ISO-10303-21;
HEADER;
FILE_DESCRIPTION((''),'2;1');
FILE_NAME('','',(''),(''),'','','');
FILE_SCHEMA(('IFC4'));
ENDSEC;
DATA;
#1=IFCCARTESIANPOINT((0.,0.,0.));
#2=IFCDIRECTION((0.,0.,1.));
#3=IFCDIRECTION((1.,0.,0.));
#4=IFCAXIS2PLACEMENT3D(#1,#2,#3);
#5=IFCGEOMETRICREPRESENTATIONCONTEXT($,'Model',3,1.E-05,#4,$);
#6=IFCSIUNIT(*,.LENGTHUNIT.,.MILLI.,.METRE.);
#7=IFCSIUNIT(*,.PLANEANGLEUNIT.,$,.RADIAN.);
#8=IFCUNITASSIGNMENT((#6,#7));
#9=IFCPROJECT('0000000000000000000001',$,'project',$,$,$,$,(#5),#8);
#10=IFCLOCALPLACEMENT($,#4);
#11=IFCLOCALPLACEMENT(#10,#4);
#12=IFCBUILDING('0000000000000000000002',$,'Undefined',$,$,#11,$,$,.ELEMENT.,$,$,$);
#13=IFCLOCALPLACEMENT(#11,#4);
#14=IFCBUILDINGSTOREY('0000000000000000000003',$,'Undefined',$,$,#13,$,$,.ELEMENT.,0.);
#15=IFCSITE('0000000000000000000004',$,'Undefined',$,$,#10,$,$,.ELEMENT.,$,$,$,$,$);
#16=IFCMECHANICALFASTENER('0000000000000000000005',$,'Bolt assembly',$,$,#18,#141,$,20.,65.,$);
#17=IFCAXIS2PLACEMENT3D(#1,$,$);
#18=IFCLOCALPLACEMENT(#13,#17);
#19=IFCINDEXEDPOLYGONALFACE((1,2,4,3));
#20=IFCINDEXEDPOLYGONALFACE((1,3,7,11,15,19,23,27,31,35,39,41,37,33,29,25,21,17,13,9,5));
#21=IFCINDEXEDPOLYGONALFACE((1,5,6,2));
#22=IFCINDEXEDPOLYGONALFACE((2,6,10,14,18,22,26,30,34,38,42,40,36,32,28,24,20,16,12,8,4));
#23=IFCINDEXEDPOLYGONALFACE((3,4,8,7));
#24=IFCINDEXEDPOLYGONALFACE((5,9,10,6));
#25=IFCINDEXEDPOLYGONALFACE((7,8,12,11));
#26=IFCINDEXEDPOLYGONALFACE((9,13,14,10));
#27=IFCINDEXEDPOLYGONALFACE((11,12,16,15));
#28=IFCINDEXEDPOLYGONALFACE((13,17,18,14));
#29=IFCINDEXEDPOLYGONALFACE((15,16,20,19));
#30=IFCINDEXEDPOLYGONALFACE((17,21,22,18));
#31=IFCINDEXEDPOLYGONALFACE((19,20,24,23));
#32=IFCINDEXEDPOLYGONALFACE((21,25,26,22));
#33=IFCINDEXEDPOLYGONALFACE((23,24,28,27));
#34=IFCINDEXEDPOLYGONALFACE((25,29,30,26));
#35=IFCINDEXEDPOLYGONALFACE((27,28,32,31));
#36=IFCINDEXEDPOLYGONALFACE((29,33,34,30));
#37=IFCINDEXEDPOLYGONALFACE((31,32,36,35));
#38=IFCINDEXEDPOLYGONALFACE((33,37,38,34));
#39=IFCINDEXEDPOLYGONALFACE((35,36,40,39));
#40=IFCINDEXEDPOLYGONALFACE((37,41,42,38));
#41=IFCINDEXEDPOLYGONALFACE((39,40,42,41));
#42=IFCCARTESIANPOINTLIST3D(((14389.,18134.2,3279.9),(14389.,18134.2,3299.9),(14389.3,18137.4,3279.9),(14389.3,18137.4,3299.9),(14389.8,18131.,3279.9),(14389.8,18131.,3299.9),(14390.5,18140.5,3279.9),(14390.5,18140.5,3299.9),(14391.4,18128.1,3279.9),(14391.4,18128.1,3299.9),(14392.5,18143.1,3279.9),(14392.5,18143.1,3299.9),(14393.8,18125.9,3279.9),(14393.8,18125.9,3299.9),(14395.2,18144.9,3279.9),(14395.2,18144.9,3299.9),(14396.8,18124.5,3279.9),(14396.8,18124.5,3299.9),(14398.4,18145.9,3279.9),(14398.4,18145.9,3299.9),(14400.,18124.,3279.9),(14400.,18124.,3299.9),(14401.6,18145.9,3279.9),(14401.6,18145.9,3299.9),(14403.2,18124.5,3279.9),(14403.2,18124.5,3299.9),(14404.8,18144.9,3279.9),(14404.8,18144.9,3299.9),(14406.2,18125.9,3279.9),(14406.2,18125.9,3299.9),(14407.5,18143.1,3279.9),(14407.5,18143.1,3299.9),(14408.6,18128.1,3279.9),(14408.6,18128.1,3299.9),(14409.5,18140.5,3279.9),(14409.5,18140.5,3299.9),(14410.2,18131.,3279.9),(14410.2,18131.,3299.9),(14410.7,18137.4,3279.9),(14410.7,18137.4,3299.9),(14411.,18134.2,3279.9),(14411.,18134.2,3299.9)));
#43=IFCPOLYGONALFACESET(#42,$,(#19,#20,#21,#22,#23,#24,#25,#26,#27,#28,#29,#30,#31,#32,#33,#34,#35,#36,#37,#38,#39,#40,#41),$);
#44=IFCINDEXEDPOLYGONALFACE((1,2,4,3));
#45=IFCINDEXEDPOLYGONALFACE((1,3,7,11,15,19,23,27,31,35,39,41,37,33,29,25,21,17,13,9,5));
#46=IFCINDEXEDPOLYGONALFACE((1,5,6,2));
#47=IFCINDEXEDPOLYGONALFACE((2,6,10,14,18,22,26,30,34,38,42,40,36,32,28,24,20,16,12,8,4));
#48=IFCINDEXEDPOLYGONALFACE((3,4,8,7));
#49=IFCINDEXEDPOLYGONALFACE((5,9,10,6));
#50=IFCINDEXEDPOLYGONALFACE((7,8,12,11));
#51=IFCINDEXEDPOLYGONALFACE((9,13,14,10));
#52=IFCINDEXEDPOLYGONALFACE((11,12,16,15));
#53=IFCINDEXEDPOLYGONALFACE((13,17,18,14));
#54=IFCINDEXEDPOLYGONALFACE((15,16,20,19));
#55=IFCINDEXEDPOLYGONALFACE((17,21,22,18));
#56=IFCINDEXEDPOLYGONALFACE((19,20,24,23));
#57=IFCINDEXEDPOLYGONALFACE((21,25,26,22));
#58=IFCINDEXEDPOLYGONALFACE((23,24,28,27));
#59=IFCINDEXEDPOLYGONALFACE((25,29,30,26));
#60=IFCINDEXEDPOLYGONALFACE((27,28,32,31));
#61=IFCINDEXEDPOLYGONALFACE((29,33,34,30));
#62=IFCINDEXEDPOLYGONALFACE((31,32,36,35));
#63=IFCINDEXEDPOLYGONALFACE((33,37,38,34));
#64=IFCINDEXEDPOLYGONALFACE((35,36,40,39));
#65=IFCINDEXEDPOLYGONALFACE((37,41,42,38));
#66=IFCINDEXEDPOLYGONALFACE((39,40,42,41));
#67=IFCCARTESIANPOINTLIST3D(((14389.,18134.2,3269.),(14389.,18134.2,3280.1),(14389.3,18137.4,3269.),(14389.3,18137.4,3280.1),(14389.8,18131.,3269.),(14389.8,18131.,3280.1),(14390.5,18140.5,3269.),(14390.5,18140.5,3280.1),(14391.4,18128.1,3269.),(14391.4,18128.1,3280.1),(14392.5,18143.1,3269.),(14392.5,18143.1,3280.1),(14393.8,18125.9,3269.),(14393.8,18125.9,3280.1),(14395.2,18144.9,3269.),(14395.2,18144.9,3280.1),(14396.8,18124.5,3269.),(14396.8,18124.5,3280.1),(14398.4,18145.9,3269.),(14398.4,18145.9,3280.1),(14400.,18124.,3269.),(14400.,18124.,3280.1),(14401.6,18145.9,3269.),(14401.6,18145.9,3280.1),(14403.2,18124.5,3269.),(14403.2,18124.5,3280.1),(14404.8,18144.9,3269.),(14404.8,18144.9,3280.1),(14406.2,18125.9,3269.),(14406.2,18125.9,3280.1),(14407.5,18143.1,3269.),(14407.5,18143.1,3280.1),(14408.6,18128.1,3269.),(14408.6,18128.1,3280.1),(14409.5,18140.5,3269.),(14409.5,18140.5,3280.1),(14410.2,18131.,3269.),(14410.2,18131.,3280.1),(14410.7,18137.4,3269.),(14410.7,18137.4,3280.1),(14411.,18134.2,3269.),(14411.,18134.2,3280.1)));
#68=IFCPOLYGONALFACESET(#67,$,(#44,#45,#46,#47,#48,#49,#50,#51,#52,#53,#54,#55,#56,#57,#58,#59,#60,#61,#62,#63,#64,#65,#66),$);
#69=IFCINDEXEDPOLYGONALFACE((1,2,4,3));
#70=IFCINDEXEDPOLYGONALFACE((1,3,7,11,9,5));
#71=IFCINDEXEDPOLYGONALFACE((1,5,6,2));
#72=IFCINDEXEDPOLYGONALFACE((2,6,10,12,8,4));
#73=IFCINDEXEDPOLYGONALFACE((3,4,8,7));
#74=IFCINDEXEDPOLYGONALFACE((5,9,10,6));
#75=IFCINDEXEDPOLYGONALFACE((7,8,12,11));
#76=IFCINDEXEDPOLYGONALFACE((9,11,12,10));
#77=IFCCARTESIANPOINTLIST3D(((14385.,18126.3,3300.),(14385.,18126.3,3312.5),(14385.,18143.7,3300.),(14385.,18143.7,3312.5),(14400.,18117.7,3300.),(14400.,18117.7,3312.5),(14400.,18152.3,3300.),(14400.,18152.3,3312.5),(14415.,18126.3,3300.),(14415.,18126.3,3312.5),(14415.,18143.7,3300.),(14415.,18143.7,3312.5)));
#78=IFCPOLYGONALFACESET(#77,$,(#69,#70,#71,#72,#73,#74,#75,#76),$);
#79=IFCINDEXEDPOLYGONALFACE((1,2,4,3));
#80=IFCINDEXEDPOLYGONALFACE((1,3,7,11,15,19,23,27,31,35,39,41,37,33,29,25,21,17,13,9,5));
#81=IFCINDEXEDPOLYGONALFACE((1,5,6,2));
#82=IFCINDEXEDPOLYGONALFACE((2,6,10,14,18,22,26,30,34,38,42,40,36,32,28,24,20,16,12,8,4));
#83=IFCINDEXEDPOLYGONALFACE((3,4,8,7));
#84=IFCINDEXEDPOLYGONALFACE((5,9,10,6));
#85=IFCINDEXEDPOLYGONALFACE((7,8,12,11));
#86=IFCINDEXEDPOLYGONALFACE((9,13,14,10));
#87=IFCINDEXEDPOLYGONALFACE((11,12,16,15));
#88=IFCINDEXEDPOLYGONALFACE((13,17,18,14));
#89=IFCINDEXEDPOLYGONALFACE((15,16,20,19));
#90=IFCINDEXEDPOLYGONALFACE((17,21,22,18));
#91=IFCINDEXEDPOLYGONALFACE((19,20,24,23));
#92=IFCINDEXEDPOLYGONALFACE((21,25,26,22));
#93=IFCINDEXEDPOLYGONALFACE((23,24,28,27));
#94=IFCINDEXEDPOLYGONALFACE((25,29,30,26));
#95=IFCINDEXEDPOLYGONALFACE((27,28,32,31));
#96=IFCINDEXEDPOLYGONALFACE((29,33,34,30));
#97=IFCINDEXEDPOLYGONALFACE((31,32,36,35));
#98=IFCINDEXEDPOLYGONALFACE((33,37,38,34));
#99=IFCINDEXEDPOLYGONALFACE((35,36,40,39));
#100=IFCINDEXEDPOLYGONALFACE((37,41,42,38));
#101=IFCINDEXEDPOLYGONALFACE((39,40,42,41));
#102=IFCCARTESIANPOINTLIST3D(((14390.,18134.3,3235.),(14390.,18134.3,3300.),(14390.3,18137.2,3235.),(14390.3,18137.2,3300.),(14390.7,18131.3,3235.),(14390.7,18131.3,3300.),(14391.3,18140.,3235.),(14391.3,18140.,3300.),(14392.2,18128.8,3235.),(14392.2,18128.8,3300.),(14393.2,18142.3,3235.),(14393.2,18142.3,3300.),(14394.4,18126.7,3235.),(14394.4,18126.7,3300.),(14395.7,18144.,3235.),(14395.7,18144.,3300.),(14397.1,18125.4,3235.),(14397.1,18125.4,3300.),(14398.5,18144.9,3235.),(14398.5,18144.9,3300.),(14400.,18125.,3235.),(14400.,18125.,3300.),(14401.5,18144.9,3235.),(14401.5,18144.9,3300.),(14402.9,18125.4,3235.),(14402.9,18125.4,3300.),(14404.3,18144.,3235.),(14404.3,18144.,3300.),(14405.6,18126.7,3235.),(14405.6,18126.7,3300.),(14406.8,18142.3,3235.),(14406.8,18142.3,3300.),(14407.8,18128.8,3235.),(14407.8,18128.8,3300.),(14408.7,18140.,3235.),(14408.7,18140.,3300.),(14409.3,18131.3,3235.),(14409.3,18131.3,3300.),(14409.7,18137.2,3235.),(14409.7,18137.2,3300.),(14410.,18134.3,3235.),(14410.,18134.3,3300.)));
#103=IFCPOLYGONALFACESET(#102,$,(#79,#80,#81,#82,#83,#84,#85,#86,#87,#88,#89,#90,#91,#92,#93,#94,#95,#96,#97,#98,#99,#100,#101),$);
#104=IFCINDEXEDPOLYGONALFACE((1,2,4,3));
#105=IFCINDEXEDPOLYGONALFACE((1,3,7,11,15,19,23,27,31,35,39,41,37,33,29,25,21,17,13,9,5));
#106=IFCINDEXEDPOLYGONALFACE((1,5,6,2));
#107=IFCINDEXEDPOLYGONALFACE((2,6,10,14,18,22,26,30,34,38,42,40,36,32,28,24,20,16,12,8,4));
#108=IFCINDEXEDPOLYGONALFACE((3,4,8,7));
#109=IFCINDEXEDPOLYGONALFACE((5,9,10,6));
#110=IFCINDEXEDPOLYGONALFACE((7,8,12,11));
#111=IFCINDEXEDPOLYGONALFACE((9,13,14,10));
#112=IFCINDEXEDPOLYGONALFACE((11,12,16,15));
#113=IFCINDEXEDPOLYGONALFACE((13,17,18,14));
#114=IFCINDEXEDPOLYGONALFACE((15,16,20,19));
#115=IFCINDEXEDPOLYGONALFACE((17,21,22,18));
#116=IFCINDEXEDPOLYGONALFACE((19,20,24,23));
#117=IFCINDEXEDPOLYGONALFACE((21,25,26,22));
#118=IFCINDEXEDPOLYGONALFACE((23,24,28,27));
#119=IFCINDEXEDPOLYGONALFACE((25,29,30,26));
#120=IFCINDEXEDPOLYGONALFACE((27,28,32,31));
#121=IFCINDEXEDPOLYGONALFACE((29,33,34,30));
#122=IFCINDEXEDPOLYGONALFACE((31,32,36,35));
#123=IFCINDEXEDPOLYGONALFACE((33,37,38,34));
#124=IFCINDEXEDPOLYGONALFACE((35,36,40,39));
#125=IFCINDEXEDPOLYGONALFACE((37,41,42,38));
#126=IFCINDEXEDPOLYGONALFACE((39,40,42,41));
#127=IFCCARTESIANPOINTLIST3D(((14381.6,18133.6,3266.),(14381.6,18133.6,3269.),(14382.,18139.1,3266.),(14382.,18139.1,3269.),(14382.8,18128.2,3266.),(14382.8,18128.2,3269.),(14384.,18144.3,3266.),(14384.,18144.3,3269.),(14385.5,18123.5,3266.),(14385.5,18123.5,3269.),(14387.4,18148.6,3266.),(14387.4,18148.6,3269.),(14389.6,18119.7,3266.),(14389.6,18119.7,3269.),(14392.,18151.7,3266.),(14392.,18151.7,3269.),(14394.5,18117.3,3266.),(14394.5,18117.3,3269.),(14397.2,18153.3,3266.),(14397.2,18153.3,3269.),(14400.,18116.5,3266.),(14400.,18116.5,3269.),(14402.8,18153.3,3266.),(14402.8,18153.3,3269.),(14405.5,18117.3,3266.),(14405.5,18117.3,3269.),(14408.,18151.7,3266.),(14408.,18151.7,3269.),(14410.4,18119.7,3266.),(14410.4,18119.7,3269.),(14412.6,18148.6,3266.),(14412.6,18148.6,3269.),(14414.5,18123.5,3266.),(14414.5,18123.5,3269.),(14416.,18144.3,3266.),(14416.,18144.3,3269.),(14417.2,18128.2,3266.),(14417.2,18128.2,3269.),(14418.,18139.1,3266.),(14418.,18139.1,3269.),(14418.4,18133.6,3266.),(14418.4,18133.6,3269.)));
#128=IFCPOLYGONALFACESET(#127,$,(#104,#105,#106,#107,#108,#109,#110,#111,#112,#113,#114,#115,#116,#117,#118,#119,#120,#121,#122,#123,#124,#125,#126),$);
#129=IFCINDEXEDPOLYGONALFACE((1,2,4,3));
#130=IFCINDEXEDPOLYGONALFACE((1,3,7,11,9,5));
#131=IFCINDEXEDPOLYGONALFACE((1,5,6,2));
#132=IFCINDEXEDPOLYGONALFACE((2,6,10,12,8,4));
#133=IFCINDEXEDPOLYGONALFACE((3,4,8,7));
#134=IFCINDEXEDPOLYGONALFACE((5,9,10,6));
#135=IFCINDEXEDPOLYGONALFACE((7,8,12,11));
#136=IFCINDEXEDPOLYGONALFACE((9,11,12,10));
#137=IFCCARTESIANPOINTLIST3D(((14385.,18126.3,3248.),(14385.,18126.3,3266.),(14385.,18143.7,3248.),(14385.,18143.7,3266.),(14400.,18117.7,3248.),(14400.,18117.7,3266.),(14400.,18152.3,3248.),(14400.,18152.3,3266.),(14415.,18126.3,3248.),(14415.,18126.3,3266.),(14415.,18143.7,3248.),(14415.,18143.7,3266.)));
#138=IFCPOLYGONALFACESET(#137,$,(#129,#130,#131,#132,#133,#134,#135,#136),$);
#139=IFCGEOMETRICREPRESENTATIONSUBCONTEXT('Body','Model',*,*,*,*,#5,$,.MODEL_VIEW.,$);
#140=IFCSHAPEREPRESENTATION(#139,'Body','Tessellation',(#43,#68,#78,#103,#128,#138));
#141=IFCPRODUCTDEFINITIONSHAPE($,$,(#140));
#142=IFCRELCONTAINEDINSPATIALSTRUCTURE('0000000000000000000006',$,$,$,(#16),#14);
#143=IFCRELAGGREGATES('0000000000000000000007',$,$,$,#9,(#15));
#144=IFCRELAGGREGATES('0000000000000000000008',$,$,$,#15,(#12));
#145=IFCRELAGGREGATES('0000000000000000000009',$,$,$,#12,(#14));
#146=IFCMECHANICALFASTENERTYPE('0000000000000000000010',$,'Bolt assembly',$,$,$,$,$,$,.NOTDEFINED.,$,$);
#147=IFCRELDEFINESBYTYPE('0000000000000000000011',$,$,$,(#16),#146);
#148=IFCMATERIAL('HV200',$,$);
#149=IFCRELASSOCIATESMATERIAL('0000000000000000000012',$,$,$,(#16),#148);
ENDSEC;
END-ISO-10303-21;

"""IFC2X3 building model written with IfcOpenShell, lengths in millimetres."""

from ifc_helpers import new_model, si_unit, frame, origin_with_axes, origin_2d_with_axis, place, context, subcontext, project, spatial, polyline, circle, outline, extrude, source, transform, mapped, material, type_object, element, save


model = new_model("IFC2X3")

# Units and contexts
model_context = context("Model", 3, precision=1e-05, world=origin_with_axes())
body_context = subcontext(model_context, "Body", "Model", "MODEL_VIEW")
ifc_project = project(units=[si_unit("LENGTHUNIT", "METRE", prefix="MILLI"), si_unit("PLANEANGLEUNIT", "RADIAN")], contexts=[model_context])

# Site, building, storey
site_placement = place(None, origin_with_axes())
site = spatial("IfcSite", under=ifc_project, at=site_placement, Name="Undefined", CompositionType="ELEMENT")
building_placement = place(site_placement, origin_with_axes())
building = spatial("IfcBuilding", under=site, at=building_placement, Name="Undefined", CompositionType="ELEMENT")
storey_placement = place(building_placement, origin_with_axes())
storey = spatial("IfcBuildingStorey", under=building, at=storey_placement, Name="Undefined", CompositionType="ELEMENT", Elevation=0.0)

# Mechanical fastener
ifc_material_1 = material(Name="HV200")
mechanical_fastener_type = type_object("IfcMechanicalFastenerType", Name="Bolt assembly")
shared_shape_1 = source(origin_with_axes(), body_context, "Body", "SweptSolid", [
    extrude(circle(Radius=11.0, at=origin_2d_with_axis()), frame((0.0, -19.9, 0.0), z_axis=(0.0, 1.0, 0.0), x_axis=(1.0, 0.0, 0.0)), (0.0, 0.0, 1.0), 20.0),
    extrude(circle(Radius=11.0, at=origin_2d_with_axis()), frame((0.0, -0.1, 0.0), z_axis=(0.0, 1.0, 0.0), x_axis=(1.0, 0.0, 0.0)), (0.0, 0.0, 1.0), 11.1),
    extrude(outline(polyline([(17.3, 0.0), (8.7, 15.0), (-8.7, 15.0), (-17.3, 0.0), (-8.7, -15.0), (8.7, -15.0), (17.3, 0.0)])), frame((0.0, -32.5, 0.0), z_axis=(0.0, 1.0, 0.0), x_axis=(1.0, 0.0, 0.0)), (0.0, 0.0, 1.0), 12.5),
    extrude(circle(Radius=10.0, at=origin_2d_with_axis()), frame((0.0, -20.0, 0.0), z_axis=(0.0, 1.0, 0.0), x_axis=(1.0, 0.0, 0.0)), (0.0, 0.0, 1.0), 65.0),
    extrude(circle(Radius=18.5, at=origin_2d_with_axis()), frame((0.0, 11.0, 0.0), z_axis=(0.0, 1.0, 0.0), x_axis=(1.0, 0.0, 0.0)), (0.0, 0.0, 1.0), 3.0),
    extrude(outline(polyline([(17.3, 0.0), (8.7, 15.0), (-8.7, 15.0), (-17.3, 0.0), (-8.7, -15.0), (8.7, -15.0), (17.3, 0.0)])), frame((0.0, 14.0, 0.0), z_axis=(0.0, 1.0, 0.0), x_axis=(1.0, 0.0, 0.0)), (0.0, 0.0, 1.0), 18.0),
])
for number, where, z_axis, x_axis, name in (
    (1, (14400.0, 18135.0, 3280.0), (1.0, 0.0, 0.0), (0.0, -1.0, 0.0), "Bolt assembly"),
):
    element("IfcMechanicalFastener", number, at=place(storey_placement, frame(where, z_axis=z_axis, x_axis=x_axis)), inside=storey, type_object=mechanical_fastener_type, material=ifc_material_1, Name=name, NominalDiameter=20.0, NominalLength=65.0, context=body_context, shape_type="MappedRepresentation", body=[
        mapped(shared_shape_1, transform((0.0, 0.0, 0.0))),
    ])

save(model, "model.ifc")
